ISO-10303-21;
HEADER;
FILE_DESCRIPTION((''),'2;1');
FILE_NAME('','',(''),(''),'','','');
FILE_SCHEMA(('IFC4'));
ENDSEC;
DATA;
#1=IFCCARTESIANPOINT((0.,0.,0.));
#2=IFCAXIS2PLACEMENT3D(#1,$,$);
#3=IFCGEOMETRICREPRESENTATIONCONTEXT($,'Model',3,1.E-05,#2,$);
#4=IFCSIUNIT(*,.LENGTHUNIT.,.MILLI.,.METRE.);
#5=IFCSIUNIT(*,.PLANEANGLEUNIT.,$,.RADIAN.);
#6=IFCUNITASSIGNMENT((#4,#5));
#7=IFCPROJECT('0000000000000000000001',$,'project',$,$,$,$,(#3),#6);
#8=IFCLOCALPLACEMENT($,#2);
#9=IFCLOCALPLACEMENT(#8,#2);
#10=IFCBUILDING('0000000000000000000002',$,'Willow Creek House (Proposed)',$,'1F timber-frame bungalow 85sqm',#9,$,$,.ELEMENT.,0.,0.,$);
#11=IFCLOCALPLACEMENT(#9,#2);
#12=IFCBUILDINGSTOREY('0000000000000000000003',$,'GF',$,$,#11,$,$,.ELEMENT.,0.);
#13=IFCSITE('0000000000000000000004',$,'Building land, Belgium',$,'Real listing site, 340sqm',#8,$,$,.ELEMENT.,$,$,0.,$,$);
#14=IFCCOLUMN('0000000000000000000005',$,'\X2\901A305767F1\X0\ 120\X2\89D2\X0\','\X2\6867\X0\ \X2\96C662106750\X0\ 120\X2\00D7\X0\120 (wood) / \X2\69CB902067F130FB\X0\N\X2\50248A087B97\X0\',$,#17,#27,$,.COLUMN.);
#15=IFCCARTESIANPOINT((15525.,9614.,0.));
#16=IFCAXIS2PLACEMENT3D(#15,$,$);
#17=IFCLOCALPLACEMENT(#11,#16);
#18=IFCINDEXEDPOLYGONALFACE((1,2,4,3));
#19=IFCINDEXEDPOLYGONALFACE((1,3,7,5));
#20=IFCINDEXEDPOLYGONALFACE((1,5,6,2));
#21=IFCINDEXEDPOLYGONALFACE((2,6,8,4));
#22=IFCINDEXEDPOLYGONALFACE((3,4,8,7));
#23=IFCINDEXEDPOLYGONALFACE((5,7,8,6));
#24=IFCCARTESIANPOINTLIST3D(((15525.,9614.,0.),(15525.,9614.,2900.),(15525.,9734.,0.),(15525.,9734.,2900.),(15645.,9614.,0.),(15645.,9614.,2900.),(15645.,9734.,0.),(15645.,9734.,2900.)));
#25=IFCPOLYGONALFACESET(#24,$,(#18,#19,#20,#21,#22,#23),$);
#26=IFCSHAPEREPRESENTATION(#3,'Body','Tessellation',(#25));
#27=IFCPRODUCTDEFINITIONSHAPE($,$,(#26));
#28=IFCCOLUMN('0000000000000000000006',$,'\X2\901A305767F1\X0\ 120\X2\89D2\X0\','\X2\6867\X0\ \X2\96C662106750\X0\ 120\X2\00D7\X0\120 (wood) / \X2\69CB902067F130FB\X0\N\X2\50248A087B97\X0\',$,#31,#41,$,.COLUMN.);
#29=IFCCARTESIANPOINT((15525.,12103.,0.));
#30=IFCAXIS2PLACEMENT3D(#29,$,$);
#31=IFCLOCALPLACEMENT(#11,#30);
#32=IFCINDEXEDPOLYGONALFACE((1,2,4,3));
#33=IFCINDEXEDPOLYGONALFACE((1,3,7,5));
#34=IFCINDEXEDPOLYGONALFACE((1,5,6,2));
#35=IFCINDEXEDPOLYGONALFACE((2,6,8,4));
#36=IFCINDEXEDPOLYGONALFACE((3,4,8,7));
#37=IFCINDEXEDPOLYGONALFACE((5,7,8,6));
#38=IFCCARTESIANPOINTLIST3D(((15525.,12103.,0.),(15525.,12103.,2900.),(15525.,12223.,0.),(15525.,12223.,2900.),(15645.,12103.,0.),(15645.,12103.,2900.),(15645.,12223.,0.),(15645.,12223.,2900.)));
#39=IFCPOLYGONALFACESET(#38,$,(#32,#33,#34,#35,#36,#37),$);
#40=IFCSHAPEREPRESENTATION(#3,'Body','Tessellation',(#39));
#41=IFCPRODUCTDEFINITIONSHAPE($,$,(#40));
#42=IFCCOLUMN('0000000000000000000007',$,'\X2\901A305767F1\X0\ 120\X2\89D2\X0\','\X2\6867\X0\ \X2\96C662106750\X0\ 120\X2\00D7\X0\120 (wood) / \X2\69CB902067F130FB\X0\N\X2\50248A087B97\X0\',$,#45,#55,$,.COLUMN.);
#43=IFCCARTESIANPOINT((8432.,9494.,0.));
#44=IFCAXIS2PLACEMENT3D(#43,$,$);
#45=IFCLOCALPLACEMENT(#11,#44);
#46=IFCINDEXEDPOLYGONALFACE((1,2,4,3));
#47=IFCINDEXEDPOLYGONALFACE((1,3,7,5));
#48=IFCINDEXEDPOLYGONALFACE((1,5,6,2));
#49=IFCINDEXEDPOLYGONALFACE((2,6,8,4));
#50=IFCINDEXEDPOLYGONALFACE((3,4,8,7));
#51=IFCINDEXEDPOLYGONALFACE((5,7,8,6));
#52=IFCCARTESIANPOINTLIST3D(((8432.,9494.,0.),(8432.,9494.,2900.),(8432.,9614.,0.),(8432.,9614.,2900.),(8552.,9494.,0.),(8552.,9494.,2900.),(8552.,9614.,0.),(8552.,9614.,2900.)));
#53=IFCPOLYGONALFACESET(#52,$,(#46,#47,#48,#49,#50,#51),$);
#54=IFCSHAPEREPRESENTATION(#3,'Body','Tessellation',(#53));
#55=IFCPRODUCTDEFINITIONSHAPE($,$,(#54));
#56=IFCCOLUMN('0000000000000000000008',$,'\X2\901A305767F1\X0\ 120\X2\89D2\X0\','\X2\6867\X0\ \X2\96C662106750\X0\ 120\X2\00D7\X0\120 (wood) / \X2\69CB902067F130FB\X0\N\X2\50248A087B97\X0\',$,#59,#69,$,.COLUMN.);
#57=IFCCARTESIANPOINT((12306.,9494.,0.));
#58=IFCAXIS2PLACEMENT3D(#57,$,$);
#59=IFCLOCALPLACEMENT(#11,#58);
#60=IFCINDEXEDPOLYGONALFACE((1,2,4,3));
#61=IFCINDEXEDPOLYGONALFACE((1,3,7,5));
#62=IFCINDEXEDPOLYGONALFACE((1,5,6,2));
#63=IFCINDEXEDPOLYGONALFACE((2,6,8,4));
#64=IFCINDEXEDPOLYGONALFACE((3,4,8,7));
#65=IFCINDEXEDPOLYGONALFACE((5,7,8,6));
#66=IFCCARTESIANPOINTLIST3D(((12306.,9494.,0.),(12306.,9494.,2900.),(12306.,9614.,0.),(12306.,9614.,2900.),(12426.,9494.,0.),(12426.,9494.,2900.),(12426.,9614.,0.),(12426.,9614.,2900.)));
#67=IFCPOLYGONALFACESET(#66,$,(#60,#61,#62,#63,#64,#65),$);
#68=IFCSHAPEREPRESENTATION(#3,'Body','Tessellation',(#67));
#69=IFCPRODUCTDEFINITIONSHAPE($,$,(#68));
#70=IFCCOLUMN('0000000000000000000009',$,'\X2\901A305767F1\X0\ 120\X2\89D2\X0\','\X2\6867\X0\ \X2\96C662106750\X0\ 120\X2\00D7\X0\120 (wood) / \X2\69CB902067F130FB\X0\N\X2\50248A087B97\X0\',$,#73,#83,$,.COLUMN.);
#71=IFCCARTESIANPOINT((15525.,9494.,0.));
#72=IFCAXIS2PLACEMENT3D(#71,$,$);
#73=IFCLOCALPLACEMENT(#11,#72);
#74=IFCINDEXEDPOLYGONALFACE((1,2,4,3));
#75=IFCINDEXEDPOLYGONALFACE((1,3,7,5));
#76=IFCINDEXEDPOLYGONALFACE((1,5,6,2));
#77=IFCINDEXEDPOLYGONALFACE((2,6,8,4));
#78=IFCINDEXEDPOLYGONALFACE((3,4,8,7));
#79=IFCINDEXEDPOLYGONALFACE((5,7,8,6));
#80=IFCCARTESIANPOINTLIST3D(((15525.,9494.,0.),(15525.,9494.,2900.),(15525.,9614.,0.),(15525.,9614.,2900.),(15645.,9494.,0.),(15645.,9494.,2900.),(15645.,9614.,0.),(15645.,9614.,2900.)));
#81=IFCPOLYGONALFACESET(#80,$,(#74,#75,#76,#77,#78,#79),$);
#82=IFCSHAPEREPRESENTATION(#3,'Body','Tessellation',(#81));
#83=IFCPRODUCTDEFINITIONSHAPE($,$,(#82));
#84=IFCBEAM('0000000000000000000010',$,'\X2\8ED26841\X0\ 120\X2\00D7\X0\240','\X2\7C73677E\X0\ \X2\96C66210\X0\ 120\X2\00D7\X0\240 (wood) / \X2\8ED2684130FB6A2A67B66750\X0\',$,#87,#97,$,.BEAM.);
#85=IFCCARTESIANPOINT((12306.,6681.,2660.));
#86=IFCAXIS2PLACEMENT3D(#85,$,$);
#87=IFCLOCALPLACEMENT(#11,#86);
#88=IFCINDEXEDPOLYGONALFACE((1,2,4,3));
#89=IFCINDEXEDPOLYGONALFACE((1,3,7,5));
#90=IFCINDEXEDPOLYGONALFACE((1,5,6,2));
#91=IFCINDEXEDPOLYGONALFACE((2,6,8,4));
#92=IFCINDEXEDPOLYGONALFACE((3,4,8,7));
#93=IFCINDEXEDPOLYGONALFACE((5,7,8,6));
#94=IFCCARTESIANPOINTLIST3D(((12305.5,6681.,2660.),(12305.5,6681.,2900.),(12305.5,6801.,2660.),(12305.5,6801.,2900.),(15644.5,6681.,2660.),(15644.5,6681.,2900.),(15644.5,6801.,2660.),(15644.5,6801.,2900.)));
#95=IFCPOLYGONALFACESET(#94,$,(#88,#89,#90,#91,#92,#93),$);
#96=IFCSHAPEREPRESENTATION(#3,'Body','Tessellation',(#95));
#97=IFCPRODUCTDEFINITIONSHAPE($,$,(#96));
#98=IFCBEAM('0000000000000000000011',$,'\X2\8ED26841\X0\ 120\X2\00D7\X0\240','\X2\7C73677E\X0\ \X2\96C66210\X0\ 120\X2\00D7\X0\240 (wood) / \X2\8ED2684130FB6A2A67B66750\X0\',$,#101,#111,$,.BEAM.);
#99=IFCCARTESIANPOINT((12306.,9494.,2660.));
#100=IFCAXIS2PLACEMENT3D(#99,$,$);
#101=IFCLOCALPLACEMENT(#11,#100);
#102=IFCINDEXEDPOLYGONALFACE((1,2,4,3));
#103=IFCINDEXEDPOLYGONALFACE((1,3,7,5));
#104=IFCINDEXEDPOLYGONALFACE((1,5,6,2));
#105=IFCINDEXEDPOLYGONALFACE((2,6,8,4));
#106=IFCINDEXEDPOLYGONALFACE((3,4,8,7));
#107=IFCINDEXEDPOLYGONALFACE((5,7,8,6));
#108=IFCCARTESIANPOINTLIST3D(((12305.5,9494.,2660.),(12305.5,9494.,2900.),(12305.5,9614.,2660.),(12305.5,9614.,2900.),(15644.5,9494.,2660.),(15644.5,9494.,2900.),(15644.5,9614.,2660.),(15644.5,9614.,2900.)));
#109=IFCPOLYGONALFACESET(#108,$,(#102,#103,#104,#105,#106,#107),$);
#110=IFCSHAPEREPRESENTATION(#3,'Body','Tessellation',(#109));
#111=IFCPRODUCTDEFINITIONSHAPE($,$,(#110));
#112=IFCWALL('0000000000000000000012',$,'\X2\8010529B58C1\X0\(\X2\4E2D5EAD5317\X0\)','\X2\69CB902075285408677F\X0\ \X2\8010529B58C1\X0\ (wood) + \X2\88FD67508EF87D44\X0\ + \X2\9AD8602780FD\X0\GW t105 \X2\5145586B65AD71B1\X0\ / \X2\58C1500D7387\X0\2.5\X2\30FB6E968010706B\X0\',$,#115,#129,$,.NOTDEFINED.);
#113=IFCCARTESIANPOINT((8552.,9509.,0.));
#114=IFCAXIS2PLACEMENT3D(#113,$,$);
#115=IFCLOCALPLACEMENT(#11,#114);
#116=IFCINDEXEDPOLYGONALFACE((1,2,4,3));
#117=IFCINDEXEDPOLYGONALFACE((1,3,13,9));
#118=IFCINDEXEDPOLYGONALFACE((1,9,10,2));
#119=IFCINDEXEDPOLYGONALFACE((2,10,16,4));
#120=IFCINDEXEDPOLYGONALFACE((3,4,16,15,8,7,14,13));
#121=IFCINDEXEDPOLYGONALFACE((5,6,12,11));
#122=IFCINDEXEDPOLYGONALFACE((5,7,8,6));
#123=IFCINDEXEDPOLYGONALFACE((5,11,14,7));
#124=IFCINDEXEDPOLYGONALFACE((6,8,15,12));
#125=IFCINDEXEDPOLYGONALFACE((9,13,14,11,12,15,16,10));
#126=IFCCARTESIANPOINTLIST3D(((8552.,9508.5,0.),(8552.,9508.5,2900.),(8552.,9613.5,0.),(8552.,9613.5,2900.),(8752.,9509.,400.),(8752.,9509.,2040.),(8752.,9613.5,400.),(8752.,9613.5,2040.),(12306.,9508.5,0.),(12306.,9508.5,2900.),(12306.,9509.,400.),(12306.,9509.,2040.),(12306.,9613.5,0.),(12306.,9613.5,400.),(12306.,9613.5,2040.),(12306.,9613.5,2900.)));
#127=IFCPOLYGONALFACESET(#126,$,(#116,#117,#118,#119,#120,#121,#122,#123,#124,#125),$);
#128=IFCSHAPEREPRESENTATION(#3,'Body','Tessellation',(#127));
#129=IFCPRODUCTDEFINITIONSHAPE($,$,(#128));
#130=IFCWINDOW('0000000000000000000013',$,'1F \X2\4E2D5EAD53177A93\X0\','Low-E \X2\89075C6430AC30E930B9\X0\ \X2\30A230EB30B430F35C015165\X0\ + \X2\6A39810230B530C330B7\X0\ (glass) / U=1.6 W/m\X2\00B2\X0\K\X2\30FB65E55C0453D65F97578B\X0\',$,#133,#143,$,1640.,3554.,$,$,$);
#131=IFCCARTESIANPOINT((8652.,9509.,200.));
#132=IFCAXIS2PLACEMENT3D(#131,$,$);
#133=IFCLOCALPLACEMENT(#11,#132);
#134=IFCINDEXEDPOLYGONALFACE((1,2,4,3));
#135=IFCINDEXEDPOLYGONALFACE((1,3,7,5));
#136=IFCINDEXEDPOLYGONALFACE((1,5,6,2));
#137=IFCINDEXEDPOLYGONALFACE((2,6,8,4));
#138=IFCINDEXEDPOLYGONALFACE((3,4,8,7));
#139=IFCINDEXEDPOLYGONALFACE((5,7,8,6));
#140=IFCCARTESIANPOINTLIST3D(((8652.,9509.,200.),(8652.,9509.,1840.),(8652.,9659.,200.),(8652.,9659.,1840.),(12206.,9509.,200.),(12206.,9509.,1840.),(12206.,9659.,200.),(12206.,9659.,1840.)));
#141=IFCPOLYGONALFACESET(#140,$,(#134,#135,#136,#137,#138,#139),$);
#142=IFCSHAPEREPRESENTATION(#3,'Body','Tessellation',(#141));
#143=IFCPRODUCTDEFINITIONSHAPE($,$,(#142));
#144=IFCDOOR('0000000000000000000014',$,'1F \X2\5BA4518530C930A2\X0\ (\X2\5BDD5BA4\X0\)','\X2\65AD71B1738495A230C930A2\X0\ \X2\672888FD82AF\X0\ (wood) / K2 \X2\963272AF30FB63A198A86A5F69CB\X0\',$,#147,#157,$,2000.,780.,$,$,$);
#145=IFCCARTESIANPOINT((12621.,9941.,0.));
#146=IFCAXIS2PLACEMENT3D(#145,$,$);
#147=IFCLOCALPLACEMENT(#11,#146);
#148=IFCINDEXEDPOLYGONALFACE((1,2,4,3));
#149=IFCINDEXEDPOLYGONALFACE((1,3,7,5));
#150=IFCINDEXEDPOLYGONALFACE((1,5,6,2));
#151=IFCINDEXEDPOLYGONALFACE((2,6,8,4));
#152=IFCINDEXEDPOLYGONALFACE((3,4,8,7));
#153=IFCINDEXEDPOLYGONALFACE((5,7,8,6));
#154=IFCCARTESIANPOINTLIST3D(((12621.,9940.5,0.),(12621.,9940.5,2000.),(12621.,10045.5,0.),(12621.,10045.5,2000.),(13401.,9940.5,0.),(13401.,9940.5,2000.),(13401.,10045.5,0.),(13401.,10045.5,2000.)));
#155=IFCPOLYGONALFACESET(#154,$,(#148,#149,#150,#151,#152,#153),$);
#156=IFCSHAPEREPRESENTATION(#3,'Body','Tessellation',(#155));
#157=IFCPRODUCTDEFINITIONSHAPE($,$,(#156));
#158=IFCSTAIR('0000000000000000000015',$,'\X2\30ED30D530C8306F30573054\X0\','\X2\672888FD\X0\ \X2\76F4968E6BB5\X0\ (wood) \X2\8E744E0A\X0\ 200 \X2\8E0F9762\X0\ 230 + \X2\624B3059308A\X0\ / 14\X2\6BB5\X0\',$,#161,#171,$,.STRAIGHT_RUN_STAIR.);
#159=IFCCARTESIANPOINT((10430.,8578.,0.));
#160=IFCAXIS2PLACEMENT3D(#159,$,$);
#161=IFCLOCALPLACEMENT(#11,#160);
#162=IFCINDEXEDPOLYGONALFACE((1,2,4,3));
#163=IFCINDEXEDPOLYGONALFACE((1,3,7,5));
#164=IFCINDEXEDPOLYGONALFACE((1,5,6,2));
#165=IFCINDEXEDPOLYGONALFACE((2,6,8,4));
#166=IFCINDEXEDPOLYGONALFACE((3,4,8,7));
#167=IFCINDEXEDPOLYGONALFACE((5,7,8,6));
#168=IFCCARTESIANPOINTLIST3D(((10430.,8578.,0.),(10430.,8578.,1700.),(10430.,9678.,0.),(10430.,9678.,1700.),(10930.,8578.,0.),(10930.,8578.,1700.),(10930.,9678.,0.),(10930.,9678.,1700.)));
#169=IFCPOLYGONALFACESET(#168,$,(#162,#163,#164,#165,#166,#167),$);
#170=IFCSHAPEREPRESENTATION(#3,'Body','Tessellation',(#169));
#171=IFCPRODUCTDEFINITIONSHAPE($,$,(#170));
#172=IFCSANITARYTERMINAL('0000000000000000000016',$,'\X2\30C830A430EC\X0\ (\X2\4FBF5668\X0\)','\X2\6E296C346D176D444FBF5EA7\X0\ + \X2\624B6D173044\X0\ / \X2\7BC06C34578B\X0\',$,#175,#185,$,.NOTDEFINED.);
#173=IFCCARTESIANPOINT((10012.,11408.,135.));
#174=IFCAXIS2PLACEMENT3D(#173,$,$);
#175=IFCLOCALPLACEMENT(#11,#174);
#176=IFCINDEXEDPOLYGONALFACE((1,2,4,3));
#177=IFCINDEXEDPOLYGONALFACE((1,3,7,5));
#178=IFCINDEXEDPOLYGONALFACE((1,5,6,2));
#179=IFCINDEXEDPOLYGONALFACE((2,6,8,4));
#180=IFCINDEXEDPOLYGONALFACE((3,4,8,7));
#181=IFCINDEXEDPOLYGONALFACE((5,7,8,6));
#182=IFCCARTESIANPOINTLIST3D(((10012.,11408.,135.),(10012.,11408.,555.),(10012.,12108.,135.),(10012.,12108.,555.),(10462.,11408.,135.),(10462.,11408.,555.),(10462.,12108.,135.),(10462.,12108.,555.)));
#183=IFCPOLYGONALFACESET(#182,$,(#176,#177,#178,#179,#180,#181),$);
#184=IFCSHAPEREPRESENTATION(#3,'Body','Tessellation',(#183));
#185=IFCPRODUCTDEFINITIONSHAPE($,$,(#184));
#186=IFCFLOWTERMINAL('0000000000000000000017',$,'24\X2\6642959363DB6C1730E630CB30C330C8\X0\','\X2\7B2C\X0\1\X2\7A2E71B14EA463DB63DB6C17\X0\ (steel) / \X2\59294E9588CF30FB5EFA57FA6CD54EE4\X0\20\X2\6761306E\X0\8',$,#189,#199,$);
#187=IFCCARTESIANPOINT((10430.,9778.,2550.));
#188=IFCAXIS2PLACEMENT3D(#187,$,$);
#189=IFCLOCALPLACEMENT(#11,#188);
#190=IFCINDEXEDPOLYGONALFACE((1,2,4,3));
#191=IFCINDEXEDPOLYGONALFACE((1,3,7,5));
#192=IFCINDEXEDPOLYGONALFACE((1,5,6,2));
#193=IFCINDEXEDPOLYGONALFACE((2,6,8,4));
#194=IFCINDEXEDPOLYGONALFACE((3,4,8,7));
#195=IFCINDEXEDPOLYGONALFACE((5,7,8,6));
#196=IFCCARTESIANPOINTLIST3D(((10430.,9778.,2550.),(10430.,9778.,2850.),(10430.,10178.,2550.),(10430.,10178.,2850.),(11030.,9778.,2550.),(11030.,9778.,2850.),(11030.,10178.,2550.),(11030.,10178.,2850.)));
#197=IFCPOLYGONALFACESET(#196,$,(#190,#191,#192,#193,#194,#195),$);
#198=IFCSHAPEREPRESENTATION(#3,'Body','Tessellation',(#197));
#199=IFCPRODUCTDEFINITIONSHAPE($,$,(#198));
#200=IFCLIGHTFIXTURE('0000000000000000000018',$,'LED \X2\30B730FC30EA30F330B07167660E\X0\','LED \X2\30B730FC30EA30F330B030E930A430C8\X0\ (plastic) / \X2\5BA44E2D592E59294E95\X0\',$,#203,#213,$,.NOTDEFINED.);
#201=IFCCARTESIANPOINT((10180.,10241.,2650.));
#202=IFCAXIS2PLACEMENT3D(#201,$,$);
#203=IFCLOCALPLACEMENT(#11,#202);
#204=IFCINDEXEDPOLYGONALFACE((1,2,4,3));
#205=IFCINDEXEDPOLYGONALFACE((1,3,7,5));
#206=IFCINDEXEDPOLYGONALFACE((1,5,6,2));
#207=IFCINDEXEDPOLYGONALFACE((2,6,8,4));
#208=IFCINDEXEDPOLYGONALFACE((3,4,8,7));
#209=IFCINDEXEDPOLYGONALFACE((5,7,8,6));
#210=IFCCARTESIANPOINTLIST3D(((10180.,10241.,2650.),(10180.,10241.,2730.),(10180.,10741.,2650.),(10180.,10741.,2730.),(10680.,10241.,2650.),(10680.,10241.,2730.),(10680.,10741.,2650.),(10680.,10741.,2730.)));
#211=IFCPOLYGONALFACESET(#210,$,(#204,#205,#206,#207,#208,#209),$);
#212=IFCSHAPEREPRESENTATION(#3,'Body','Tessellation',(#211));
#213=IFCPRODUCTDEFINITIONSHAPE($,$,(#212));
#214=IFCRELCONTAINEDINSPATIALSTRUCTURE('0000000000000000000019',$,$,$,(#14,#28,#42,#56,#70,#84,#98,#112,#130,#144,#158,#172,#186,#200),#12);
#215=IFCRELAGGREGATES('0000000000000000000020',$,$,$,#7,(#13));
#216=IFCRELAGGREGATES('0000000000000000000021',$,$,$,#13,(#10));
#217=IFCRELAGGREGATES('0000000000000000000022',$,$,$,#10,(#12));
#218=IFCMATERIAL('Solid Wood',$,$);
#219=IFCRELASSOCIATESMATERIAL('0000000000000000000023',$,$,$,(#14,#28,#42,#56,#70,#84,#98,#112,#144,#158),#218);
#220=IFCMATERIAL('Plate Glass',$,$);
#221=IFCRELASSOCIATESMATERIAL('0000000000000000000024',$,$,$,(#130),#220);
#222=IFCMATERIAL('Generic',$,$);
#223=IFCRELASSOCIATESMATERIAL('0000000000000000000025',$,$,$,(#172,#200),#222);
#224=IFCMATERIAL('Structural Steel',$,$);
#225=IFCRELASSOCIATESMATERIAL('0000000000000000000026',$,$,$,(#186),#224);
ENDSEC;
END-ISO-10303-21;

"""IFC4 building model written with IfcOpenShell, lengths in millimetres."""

from ifc_helpers import new_model, si_unit, frame, frame_2d, origin, place, context, project, spatial, rectangle, extrude, material, element, fill, save


model = new_model("IFC4")

# Units and contexts
model_context = context("Model", 3, precision=1e-05, world=origin())
ifc_project = project(units=[si_unit("LENGTHUNIT", "METRE", prefix="MILLI"), si_unit("PLANEANGLEUNIT", "RADIAN")], contexts=[model_context])

# Site, building, storey
site_placement = place(None, origin())
site = spatial("IfcSite", under=ifc_project, at=site_placement, Name="Building land, Belgium", ObjectType="Real listing site, 340sqm", CompositionType="ELEMENT", RefElevation=0.0)
building_placement = place(site_placement, origin())
building = spatial("IfcBuilding", under=site, at=building_placement, Name="Willow Creek House (Proposed)", ObjectType="1F timber-frame bungalow 85sqm", CompositionType="ELEMENT", ElevationOfRefHeight=0.0, ElevationOfTerrain=0.0)
storey_placement = place(building_placement, origin())
storey = spatial("IfcBuildingStorey", under=building, at=storey_placement, Name="GF", CompositionType="ELEMENT", Elevation=0.0)

# Columns
ifc_material_1 = material(Name="Solid Wood")
column_1_placement = place(storey_placement, frame((15525.0, 9614.0, 0.0)))
element("IfcColumn", 1, at=column_1_placement, inside=storey, material=ifc_material_1, Name="通し柱 120角", Description="桧 集成材 120×120 (wood) / 構造柱・N値計算", PredefinedType="COLUMN", context=model_context, shape_type="SweptSolid", body=[
    extrude(rectangle(XDim=120.0, YDim=120.0, at=frame_2d((60.0, 60.0))), frame((15525.0, 9614.0, 0.0)), (0.0, 0.0, 1.0), 2900.0),
])
column_2_placement = place(storey_placement, frame((15525.0, 12103.0, 0.0)))
element("IfcColumn", 2, at=column_2_placement, inside=storey, material=ifc_material_1, Name="通し柱 120角", Description="桧 集成材 120×120 (wood) / 構造柱・N値計算", PredefinedType="COLUMN", context=model_context, shape_type="SweptSolid", body=[
    extrude(rectangle(XDim=120.0, YDim=120.0, at=frame_2d((60.0, 60.0))), frame((15525.0, 12103.0, 0.0)), (0.0, 0.0, 1.0), 2900.0),
])
column_3_placement = place(storey_placement, frame((8432.0, 9494.0, 0.0)))
element("IfcColumn", 3, at=column_3_placement, inside=storey, material=ifc_material_1, Name="通し柱 120角", Description="桧 集成材 120×120 (wood) / 構造柱・N値計算", PredefinedType="COLUMN", context=model_context, shape_type="SweptSolid", body=[
    extrude(rectangle(XDim=120.0, YDim=120.0, at=frame_2d((60.0, 60.0))), frame((8432.0, 9494.0, 0.0)), (0.0, 0.0, 1.0), 2900.0),
])
column_4_placement = place(storey_placement, frame((12306.0, 9494.0, 0.0)))
element("IfcColumn", 4, at=column_4_placement, inside=storey, material=ifc_material_1, Name="通し柱 120角", Description="桧 集成材 120×120 (wood) / 構造柱・N値計算", PredefinedType="COLUMN", context=model_context, shape_type="SweptSolid", body=[
    extrude(rectangle(XDim=120.0, YDim=120.0, at=frame_2d((60.0, 60.0))), frame((12306.0, 9494.0, 0.0)), (0.0, 0.0, 1.0), 2900.0),
])
column_5_placement = place(storey_placement, frame((15525.0, 9494.0, 0.0)))
element("IfcColumn", 5, at=column_5_placement, inside=storey, material=ifc_material_1, Name="通し柱 120角", Description="桧 集成材 120×120 (wood) / 構造柱・N値計算", PredefinedType="COLUMN", context=model_context, shape_type="SweptSolid", body=[
    extrude(rectangle(XDim=120.0, YDim=120.0, at=frame_2d((60.0, 60.0))), frame((15525.0, 9494.0, 0.0)), (0.0, 0.0, 1.0), 2900.0),
])

# Beams
beam_1_placement = place(storey_placement, frame((12306.0, 6681.0, 2660.0)))
element("IfcBeam", 6, at=beam_1_placement, inside=storey, material=ifc_material_1, Name="軒桁 120×240", Description="米松 集成 120×240 (wood) / 軒桁・横架材", PredefinedType="BEAM", context=model_context, shape_type="SweptSolid", body=[
    extrude(rectangle(XDim=3339.0, YDim=120.0, at=frame_2d((1669.0, 60.0))), frame((12306.0, 6681.0, 2660.0)), (0.0, 0.0, 1.0), 240.0),
])
beam_2_placement = place(storey_placement, frame((12306.0, 9494.0, 2660.0)))
element("IfcBeam", 7, at=beam_2_placement, inside=storey, material=ifc_material_1, Name="軒桁 120×240", Description="米松 集成 120×240 (wood) / 軒桁・横架材", PredefinedType="BEAM", context=model_context, shape_type="SweptSolid", body=[
    extrude(rectangle(XDim=3339.0, YDim=120.0, at=frame_2d((1669.0, 60.0))), frame((12306.0, 9494.0, 2660.0)), (0.0, 0.0, 1.0), 240.0),
])

# Wall, opening, window
wall_1_placement = place(storey_placement, frame((8552.0, 9509.0, 0.0)))
wall_1 = element("IfcWall", 8, at=wall_1_placement, inside=storey, material=ifc_material_1, Name="耐力壁(中庭北)", Description="構造用合板 耐力壁 (wood) + 製材軸組 + 高性能GW t105 充填断熱 / 壁倍率2.5・準耐火", PredefinedType="NOTDEFINED", context=model_context, shape_type="SweptSolid", body=[
    extrude(rectangle(XDim=3754.0, YDim=105.0, at=frame_2d((1877.0, 52.0))), frame((8552.0, 9509.0, 0.0)), (0.0, 0.0, 1.0), 2900.0),
])
opening_placement = place(storey_placement, frame((8652.0, 9509.0, 200.0)))
opening = element("IfcOpeningElement", 9, at=opening_placement, cuts=wall_1, PredefinedType="NOTDEFINED", context=model_context, shape_type="SweptSolid", body=[
    extrude(rectangle(XDim=3554.0, YDim=150.0, at=frame_2d((1777.0, 75.0))), frame((8652.0, 9509.0, 200.0)), (0.0, 0.0, 1.0), 1640.0),
])
ifc_material_2 = material(Name="Plate Glass")
window_placement = place(storey_placement, frame((8652.0, 9509.0, 200.0)))
window = element("IfcWindow", 10, at=window_placement, inside=storey, material=ifc_material_2, Name="1F 中庭北窓", Description="Low-E 複層ガラス アルゴン封入 + 樹脂サッシ (glass) / U=1.6 W/m²K・日射取得型", OverallHeight=1640.0, OverallWidth=3554.0, context=model_context, shape_type="SweptSolid", body=[
    extrude(rectangle(XDim=3554.0, YDim=150.0, at=frame_2d((1777.0, 75.0))), frame((8652.0, 9509.0, 200.0)), (0.0, 0.0, 1.0), 1640.0),
])
fill(opening, window)

# Door
door_placement = place(storey_placement, frame((12621.0, 9941.0, 0.0)))
element("IfcDoor", 11, at=door_placement, inside=storey, material=ifc_material_1, Name="1F 室内ドア (寝室)", Description="断熱玄関ドア 木製芯 (wood) / K2 防犯・採風機構", OverallHeight=2000.0, OverallWidth=780.0, context=model_context, shape_type="SweptSolid", body=[
    extrude(rectangle(XDim=780.0, YDim=105.0, at=frame_2d((390.0, 52.0))), frame((12621.0, 9941.0, 0.0)), (0.0, 0.0, 1.0), 2000.0),
])

# Stair
stair_placement = place(storey_placement, frame((10430.0, 8578.0, 0.0)))
element("IfcStair", 12, at=stair_placement, inside=storey, material=ifc_material_1, Name="ロフトはしご", Description="木製 直階段 (wood) 蹴上 200 踏面 230 + 手すり / 14段", PredefinedType="STRAIGHT_RUN_STAIR", context=model_context, shape_type="SweptSolid", body=[
    extrude(rectangle(XDim=500.0, YDim=1100.0, at=frame_2d((250.0, 550.0))), frame((10430.0, 8578.0, 0.0)), (0.0, 0.0, 1.0), 1700.0),
])

# Shared definitions
ifc_material_3 = material(Name="Generic")

# Sanitary terminal
sanitary_terminal_placement = place(storey_placement, frame((10012.0, 11408.0, 135.0)))
element("IfcSanitaryTerminal", 13, at=sanitary_terminal_placement, inside=storey, material=ifc_material_3, Name="トイレ (便器)", Description="温水洗浄便座 + 手洗い / 節水型", PredefinedType="NOTDEFINED", context=model_context, shape_type="SweptSolid", body=[
    extrude(rectangle(XDim=450.0, YDim=700.0, at=frame_2d((225.0, 350.0))), frame((10012.0, 11408.0, 135.0)), (0.0, 0.0, 1.0), 420.0),
])

# Flow terminal
ifc_material_4 = material(Name="Structural Steel")
flow_terminal_placement = place(storey_placement, frame((10430.0, 9778.0, 2550.0)))
element("IfcFlowTerminal", 14, at=flow_terminal_placement, inside=storey, material=ifc_material_4, Name="24時間換気ユニット", Description="第1種熱交換換気 (steel) / 天井裏・建基法令20条の8", context=model_context, shape_type="SweptSolid", body=[
    extrude(rectangle(XDim=600.0, YDim=400.0, at=frame_2d((300.0, 200.0))), frame((10430.0, 9778.0, 2550.0)), (0.0, 0.0, 1.0), 300.0),
])

# Light fixture
light_fixture_1_placement = place(storey_placement, frame((10180.0, 10241.0, 2650.0)))
element("IfcLightFixture", 15, at=light_fixture_1_placement, inside=storey, material=ifc_material_3, Name="LED シーリング照明", Description="LED シーリングライト (plastic) / 室中央天井", PredefinedType="NOTDEFINED", context=model_context, shape_type="SweptSolid", body=[
    extrude(rectangle(XDim=500.0, YDim=500.0, at=frame_2d((250.0, 250.0))), frame((10180.0, 10241.0, 2650.0)), (0.0, 0.0, 1.0), 80.0),
])

save(model, "model.ifc")
